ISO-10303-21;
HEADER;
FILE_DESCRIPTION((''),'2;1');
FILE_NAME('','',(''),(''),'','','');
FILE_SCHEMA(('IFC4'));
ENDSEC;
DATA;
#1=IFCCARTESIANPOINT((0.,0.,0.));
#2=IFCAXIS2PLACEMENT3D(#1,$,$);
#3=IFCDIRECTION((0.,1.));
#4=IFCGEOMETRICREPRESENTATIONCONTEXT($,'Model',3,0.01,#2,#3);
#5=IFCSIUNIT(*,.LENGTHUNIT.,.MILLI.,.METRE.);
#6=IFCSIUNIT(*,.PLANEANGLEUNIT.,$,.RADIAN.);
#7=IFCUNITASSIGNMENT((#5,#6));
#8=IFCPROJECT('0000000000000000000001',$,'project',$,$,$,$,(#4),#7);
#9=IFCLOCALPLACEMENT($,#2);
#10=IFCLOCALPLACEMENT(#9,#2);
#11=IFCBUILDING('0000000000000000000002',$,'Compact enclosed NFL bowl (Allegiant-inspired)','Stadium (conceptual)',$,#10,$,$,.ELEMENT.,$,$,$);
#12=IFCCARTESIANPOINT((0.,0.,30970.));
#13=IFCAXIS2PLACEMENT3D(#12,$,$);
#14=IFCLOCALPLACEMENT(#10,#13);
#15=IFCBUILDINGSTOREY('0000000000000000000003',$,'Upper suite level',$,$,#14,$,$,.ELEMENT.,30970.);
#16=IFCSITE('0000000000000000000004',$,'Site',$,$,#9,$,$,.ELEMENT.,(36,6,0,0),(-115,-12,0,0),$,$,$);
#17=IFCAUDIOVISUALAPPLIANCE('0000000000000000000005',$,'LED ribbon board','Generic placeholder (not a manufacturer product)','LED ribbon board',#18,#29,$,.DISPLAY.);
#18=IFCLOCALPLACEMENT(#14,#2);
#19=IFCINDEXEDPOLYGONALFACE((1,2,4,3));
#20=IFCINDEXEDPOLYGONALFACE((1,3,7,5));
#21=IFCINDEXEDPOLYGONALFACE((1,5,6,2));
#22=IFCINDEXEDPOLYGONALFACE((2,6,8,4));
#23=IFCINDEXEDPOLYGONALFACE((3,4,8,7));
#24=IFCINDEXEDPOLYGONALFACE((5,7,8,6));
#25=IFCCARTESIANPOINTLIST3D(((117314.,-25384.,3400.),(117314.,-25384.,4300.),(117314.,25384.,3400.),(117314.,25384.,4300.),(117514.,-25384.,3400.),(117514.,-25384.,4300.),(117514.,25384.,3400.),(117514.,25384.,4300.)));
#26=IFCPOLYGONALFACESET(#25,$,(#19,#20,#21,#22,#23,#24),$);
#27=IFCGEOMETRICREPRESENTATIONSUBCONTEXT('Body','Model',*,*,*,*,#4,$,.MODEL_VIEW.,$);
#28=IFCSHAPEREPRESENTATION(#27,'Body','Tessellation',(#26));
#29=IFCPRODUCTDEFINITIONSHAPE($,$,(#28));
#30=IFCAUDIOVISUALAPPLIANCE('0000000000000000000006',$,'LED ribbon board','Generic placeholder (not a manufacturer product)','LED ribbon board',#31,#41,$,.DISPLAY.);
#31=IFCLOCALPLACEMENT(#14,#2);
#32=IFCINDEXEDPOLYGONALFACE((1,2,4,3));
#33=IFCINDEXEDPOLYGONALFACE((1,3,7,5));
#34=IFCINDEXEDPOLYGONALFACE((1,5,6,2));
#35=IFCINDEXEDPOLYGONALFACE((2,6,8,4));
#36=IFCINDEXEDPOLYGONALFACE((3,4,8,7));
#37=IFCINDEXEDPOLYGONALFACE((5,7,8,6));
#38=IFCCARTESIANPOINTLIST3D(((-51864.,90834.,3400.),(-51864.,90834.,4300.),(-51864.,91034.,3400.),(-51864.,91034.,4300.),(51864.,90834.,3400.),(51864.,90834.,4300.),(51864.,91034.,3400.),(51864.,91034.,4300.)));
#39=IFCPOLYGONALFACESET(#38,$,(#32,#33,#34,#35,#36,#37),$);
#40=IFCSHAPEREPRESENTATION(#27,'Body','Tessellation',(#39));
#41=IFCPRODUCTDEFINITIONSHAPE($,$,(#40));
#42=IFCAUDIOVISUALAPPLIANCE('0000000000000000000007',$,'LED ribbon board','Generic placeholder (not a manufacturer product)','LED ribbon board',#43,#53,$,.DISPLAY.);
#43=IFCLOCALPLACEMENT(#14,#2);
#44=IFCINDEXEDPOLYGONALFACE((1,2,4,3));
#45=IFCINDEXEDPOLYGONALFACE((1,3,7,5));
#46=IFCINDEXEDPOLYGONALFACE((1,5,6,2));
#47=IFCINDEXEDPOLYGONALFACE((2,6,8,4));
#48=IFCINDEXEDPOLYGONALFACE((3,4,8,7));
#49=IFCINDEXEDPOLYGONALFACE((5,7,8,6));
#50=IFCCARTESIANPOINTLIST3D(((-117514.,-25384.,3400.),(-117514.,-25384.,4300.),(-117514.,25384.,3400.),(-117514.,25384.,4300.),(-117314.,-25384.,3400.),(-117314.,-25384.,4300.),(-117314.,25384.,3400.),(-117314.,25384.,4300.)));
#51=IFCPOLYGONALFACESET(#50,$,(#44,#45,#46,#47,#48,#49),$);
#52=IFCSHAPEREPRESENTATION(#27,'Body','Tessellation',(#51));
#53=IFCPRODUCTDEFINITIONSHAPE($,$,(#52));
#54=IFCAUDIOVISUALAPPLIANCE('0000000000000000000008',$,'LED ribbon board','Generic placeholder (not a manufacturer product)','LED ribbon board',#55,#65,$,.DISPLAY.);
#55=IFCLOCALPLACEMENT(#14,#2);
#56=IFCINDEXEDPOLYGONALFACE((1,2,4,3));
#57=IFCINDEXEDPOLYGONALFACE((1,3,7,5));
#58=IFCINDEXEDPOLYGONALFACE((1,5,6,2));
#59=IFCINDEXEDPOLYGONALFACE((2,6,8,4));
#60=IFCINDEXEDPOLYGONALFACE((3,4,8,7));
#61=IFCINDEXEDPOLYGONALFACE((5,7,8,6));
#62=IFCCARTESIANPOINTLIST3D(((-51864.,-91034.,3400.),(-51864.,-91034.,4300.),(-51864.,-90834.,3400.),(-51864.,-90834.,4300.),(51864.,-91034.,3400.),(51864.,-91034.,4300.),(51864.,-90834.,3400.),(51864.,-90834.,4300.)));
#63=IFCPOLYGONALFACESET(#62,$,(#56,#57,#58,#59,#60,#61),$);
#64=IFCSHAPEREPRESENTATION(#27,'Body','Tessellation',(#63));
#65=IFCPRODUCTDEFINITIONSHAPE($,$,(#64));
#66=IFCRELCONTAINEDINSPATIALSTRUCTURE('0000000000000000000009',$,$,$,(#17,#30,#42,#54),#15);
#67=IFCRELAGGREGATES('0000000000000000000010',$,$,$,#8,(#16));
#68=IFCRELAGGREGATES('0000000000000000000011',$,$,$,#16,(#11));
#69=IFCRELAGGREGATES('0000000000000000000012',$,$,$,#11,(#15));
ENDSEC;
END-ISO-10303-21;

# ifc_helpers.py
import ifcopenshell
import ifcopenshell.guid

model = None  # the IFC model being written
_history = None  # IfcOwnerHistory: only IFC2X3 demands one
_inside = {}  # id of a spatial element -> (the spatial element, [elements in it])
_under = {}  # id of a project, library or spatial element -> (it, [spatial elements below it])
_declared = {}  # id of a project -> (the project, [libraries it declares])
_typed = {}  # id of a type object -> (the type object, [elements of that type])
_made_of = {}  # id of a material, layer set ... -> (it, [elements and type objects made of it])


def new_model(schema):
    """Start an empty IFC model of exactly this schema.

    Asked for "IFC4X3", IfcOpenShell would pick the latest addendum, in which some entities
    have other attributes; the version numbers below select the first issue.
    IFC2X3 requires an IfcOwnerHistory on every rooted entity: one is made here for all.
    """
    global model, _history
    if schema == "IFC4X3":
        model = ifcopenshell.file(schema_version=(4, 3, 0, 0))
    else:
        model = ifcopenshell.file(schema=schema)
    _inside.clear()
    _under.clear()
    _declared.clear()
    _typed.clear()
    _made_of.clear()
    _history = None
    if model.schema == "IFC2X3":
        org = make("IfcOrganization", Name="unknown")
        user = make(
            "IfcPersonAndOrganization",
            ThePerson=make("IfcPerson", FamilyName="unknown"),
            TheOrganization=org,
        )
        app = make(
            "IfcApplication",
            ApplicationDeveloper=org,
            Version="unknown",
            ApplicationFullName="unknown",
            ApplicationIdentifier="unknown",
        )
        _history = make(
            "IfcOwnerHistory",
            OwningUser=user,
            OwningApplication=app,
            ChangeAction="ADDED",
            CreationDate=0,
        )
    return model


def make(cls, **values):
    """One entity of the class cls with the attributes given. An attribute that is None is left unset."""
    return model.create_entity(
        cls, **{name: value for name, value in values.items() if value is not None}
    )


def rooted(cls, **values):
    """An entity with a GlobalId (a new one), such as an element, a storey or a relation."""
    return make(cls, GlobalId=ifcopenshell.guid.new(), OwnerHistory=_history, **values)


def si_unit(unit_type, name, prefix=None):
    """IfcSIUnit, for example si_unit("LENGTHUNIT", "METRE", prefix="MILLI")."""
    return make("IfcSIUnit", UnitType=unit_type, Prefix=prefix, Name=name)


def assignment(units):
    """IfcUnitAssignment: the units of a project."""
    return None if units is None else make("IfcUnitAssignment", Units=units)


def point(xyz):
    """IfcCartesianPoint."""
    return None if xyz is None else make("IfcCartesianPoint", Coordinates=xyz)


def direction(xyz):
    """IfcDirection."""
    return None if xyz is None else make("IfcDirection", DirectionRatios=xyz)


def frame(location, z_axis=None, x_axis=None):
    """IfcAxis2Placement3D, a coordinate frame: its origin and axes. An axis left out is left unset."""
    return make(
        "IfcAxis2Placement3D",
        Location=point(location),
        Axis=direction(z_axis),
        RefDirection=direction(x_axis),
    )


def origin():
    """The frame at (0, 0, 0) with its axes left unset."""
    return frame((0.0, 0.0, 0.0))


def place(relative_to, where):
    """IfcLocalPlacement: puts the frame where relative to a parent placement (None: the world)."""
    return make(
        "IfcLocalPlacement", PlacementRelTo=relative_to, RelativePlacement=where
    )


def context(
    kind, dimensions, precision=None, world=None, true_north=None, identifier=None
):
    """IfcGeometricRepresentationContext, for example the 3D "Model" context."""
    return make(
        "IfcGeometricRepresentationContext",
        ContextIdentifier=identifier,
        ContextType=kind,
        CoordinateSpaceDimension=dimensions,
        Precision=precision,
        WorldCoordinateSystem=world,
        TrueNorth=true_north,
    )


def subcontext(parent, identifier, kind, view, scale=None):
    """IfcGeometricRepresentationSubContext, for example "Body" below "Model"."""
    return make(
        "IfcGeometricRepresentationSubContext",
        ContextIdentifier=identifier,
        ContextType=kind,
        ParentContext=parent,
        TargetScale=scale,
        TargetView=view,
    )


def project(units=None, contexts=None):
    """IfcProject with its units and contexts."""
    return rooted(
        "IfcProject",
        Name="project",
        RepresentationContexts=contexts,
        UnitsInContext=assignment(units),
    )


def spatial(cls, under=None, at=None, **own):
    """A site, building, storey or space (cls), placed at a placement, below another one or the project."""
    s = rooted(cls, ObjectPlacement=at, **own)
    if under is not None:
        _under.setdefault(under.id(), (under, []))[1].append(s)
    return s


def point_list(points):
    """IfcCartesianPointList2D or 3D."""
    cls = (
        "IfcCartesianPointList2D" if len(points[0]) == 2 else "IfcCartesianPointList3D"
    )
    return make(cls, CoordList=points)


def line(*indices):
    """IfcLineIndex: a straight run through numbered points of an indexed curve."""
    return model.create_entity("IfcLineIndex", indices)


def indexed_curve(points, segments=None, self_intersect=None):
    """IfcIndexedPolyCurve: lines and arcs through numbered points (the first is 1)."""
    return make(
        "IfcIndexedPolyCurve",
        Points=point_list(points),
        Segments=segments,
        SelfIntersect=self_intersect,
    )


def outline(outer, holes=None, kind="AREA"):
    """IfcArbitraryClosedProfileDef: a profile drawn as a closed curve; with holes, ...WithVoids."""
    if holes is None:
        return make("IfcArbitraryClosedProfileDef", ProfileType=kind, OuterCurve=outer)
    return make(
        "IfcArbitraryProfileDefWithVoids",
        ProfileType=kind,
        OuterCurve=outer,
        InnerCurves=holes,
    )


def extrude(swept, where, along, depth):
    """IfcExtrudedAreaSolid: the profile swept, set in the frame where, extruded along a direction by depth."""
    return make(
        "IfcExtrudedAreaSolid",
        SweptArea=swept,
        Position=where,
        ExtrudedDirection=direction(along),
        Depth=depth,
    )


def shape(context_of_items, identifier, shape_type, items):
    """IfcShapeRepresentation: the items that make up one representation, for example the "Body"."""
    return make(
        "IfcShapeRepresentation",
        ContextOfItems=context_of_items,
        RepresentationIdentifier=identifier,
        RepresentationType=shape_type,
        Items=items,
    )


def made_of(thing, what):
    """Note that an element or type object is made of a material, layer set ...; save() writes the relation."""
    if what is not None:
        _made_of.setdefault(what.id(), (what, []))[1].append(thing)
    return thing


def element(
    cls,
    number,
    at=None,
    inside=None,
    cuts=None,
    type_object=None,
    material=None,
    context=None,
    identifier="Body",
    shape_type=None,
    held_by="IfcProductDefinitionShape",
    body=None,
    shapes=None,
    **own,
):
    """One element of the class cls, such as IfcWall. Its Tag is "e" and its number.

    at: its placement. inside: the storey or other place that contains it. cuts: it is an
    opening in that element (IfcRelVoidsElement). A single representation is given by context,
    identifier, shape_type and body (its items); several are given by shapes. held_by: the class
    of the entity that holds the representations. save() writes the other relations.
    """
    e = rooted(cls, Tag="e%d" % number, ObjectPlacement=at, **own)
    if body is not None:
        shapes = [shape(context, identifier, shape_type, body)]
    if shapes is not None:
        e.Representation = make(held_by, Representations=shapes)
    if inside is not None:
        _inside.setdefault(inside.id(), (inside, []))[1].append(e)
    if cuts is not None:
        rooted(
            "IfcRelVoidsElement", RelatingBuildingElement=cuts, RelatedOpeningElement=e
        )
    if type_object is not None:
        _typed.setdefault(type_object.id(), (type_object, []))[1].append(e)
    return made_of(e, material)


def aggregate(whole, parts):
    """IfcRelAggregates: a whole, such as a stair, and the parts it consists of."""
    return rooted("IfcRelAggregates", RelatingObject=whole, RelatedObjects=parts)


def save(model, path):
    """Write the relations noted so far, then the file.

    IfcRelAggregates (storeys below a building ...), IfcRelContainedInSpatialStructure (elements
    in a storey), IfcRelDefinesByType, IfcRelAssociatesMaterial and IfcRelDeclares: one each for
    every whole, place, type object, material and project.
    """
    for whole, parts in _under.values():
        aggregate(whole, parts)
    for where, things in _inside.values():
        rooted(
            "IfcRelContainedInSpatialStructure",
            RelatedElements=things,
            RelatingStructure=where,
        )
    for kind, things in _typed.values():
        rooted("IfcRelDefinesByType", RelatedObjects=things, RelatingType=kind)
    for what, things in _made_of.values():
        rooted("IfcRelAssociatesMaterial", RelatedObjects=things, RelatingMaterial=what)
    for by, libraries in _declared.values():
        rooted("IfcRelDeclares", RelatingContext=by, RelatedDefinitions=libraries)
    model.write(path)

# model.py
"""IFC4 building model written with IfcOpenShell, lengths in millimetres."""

from ifc_helpers import new_model, si_unit, direction, frame, origin, place, context, subcontext, project, spatial, line, indexed_curve, outline, extrude, element, save


model = new_model("IFC4")

# Units and contexts
model_context = context("Model", 3, precision=0.01, world=origin(), true_north=direction((0.0, 1.0)))
body_context = subcontext(model_context, "Body", "Model", "MODEL_VIEW")
ifc_project = project(units=[si_unit("LENGTHUNIT", "METRE", prefix="MILLI"), si_unit("PLANEANGLEUNIT", "RADIAN")], contexts=[model_context])

# Site, building, storey
site_placement = place(None, origin())
site = spatial("IfcSite", under=ifc_project, at=site_placement, Name="Site", CompositionType="ELEMENT", RefLatitude=(36, 6, 0, 0), RefLongitude=(-115, -12, 0, 0))
building_placement = place(site_placement, origin())
building = spatial("IfcBuilding", under=site, at=building_placement, Name="Compact enclosed NFL bowl (Allegiant-inspired)", Description="Stadium (conceptual)", CompositionType="ELEMENT")
storey_placement = place(building_placement, frame((0.0, 0.0, 30970.0)))
storey = spatial("IfcBuildingStorey", under=building, at=storey_placement, Name="Upper suite level", CompositionType="ELEMENT", Elevation=30970.0)

# Shared definitions
placement = place(storey_placement, frame((0.0, 0.0, -30970.0)))

# Audio visual appliances
element("IfcAudioVisualAppliance", 1, at=placement, inside=storey, Name="LED ribbon board", Description="Generic placeholder (not a manufacturer product)", ObjectType="LED ribbon board", PredefinedType="DISPLAY", context=body_context, shape_type="SweptSolid", body=[
    extrude(outline(indexed_curve([(117314.0, -25384.0), (117314.0, 25384.0), (117514.0, 25384.0), (117514.0, -25384.0)], segments=[line(1, 2), line(2, 3), line(3, 4), line(4, 1)], self_intersect=False)), frame((0.0, 0.0, 34370.0)), (0.0, 0.0, 1.0), 900.0),
])
element("IfcAudioVisualAppliance", 2, at=placement, inside=storey, Name="LED ribbon board", Description="Generic placeholder (not a manufacturer product)", ObjectType="LED ribbon board", PredefinedType="DISPLAY", context=body_context, shape_type="SweptSolid", body=[
    extrude(outline(indexed_curve([(51864.0, 90834.0), (-51864.0, 90834.0), (-51864.0, 91034.0), (51864.0, 91034.0)], segments=[line(1, 2), line(2, 3), line(3, 4), line(4, 1)], self_intersect=False)), frame((0.0, 0.0, 34370.0)), (0.0, 0.0, 1.0), 900.0),
])
element("IfcAudioVisualAppliance", 3, at=placement, inside=storey, Name="LED ribbon board", Description="Generic placeholder (not a manufacturer product)", ObjectType="LED ribbon board", PredefinedType="DISPLAY", context=body_context, shape_type="SweptSolid", body=[
    extrude(outline(indexed_curve([(-117314.0, 25384.0), (-117314.0, -25384.0), (-117514.0, -25384.0), (-117514.0, 25384.0)], segments=[line(1, 2), line(2, 3), line(3, 4), line(4, 1)], self_intersect=False)), frame((0.0, 0.0, 34370.0)), (0.0, 0.0, 1.0), 900.0),
])
element("IfcAudioVisualAppliance", 4, at=placement, inside=storey, Name="LED ribbon board", Description="Generic placeholder (not a manufacturer product)", ObjectType="LED ribbon board", PredefinedType="DISPLAY", context=body_context, shape_type="SweptSolid", body=[
    extrude(outline(indexed_curve([(-51864.0, -90834.0), (51864.0, -90834.0), (51864.0, -91034.0), (-51864.0, -91034.0)], segments=[line(1, 2), line(2, 3), line(3, 4), line(4, 1)], self_intersect=False)), frame((0.0, 0.0, 34370.0)), (0.0, 0.0, 1.0), 900.0),
])

save(model, "model.ifc")
